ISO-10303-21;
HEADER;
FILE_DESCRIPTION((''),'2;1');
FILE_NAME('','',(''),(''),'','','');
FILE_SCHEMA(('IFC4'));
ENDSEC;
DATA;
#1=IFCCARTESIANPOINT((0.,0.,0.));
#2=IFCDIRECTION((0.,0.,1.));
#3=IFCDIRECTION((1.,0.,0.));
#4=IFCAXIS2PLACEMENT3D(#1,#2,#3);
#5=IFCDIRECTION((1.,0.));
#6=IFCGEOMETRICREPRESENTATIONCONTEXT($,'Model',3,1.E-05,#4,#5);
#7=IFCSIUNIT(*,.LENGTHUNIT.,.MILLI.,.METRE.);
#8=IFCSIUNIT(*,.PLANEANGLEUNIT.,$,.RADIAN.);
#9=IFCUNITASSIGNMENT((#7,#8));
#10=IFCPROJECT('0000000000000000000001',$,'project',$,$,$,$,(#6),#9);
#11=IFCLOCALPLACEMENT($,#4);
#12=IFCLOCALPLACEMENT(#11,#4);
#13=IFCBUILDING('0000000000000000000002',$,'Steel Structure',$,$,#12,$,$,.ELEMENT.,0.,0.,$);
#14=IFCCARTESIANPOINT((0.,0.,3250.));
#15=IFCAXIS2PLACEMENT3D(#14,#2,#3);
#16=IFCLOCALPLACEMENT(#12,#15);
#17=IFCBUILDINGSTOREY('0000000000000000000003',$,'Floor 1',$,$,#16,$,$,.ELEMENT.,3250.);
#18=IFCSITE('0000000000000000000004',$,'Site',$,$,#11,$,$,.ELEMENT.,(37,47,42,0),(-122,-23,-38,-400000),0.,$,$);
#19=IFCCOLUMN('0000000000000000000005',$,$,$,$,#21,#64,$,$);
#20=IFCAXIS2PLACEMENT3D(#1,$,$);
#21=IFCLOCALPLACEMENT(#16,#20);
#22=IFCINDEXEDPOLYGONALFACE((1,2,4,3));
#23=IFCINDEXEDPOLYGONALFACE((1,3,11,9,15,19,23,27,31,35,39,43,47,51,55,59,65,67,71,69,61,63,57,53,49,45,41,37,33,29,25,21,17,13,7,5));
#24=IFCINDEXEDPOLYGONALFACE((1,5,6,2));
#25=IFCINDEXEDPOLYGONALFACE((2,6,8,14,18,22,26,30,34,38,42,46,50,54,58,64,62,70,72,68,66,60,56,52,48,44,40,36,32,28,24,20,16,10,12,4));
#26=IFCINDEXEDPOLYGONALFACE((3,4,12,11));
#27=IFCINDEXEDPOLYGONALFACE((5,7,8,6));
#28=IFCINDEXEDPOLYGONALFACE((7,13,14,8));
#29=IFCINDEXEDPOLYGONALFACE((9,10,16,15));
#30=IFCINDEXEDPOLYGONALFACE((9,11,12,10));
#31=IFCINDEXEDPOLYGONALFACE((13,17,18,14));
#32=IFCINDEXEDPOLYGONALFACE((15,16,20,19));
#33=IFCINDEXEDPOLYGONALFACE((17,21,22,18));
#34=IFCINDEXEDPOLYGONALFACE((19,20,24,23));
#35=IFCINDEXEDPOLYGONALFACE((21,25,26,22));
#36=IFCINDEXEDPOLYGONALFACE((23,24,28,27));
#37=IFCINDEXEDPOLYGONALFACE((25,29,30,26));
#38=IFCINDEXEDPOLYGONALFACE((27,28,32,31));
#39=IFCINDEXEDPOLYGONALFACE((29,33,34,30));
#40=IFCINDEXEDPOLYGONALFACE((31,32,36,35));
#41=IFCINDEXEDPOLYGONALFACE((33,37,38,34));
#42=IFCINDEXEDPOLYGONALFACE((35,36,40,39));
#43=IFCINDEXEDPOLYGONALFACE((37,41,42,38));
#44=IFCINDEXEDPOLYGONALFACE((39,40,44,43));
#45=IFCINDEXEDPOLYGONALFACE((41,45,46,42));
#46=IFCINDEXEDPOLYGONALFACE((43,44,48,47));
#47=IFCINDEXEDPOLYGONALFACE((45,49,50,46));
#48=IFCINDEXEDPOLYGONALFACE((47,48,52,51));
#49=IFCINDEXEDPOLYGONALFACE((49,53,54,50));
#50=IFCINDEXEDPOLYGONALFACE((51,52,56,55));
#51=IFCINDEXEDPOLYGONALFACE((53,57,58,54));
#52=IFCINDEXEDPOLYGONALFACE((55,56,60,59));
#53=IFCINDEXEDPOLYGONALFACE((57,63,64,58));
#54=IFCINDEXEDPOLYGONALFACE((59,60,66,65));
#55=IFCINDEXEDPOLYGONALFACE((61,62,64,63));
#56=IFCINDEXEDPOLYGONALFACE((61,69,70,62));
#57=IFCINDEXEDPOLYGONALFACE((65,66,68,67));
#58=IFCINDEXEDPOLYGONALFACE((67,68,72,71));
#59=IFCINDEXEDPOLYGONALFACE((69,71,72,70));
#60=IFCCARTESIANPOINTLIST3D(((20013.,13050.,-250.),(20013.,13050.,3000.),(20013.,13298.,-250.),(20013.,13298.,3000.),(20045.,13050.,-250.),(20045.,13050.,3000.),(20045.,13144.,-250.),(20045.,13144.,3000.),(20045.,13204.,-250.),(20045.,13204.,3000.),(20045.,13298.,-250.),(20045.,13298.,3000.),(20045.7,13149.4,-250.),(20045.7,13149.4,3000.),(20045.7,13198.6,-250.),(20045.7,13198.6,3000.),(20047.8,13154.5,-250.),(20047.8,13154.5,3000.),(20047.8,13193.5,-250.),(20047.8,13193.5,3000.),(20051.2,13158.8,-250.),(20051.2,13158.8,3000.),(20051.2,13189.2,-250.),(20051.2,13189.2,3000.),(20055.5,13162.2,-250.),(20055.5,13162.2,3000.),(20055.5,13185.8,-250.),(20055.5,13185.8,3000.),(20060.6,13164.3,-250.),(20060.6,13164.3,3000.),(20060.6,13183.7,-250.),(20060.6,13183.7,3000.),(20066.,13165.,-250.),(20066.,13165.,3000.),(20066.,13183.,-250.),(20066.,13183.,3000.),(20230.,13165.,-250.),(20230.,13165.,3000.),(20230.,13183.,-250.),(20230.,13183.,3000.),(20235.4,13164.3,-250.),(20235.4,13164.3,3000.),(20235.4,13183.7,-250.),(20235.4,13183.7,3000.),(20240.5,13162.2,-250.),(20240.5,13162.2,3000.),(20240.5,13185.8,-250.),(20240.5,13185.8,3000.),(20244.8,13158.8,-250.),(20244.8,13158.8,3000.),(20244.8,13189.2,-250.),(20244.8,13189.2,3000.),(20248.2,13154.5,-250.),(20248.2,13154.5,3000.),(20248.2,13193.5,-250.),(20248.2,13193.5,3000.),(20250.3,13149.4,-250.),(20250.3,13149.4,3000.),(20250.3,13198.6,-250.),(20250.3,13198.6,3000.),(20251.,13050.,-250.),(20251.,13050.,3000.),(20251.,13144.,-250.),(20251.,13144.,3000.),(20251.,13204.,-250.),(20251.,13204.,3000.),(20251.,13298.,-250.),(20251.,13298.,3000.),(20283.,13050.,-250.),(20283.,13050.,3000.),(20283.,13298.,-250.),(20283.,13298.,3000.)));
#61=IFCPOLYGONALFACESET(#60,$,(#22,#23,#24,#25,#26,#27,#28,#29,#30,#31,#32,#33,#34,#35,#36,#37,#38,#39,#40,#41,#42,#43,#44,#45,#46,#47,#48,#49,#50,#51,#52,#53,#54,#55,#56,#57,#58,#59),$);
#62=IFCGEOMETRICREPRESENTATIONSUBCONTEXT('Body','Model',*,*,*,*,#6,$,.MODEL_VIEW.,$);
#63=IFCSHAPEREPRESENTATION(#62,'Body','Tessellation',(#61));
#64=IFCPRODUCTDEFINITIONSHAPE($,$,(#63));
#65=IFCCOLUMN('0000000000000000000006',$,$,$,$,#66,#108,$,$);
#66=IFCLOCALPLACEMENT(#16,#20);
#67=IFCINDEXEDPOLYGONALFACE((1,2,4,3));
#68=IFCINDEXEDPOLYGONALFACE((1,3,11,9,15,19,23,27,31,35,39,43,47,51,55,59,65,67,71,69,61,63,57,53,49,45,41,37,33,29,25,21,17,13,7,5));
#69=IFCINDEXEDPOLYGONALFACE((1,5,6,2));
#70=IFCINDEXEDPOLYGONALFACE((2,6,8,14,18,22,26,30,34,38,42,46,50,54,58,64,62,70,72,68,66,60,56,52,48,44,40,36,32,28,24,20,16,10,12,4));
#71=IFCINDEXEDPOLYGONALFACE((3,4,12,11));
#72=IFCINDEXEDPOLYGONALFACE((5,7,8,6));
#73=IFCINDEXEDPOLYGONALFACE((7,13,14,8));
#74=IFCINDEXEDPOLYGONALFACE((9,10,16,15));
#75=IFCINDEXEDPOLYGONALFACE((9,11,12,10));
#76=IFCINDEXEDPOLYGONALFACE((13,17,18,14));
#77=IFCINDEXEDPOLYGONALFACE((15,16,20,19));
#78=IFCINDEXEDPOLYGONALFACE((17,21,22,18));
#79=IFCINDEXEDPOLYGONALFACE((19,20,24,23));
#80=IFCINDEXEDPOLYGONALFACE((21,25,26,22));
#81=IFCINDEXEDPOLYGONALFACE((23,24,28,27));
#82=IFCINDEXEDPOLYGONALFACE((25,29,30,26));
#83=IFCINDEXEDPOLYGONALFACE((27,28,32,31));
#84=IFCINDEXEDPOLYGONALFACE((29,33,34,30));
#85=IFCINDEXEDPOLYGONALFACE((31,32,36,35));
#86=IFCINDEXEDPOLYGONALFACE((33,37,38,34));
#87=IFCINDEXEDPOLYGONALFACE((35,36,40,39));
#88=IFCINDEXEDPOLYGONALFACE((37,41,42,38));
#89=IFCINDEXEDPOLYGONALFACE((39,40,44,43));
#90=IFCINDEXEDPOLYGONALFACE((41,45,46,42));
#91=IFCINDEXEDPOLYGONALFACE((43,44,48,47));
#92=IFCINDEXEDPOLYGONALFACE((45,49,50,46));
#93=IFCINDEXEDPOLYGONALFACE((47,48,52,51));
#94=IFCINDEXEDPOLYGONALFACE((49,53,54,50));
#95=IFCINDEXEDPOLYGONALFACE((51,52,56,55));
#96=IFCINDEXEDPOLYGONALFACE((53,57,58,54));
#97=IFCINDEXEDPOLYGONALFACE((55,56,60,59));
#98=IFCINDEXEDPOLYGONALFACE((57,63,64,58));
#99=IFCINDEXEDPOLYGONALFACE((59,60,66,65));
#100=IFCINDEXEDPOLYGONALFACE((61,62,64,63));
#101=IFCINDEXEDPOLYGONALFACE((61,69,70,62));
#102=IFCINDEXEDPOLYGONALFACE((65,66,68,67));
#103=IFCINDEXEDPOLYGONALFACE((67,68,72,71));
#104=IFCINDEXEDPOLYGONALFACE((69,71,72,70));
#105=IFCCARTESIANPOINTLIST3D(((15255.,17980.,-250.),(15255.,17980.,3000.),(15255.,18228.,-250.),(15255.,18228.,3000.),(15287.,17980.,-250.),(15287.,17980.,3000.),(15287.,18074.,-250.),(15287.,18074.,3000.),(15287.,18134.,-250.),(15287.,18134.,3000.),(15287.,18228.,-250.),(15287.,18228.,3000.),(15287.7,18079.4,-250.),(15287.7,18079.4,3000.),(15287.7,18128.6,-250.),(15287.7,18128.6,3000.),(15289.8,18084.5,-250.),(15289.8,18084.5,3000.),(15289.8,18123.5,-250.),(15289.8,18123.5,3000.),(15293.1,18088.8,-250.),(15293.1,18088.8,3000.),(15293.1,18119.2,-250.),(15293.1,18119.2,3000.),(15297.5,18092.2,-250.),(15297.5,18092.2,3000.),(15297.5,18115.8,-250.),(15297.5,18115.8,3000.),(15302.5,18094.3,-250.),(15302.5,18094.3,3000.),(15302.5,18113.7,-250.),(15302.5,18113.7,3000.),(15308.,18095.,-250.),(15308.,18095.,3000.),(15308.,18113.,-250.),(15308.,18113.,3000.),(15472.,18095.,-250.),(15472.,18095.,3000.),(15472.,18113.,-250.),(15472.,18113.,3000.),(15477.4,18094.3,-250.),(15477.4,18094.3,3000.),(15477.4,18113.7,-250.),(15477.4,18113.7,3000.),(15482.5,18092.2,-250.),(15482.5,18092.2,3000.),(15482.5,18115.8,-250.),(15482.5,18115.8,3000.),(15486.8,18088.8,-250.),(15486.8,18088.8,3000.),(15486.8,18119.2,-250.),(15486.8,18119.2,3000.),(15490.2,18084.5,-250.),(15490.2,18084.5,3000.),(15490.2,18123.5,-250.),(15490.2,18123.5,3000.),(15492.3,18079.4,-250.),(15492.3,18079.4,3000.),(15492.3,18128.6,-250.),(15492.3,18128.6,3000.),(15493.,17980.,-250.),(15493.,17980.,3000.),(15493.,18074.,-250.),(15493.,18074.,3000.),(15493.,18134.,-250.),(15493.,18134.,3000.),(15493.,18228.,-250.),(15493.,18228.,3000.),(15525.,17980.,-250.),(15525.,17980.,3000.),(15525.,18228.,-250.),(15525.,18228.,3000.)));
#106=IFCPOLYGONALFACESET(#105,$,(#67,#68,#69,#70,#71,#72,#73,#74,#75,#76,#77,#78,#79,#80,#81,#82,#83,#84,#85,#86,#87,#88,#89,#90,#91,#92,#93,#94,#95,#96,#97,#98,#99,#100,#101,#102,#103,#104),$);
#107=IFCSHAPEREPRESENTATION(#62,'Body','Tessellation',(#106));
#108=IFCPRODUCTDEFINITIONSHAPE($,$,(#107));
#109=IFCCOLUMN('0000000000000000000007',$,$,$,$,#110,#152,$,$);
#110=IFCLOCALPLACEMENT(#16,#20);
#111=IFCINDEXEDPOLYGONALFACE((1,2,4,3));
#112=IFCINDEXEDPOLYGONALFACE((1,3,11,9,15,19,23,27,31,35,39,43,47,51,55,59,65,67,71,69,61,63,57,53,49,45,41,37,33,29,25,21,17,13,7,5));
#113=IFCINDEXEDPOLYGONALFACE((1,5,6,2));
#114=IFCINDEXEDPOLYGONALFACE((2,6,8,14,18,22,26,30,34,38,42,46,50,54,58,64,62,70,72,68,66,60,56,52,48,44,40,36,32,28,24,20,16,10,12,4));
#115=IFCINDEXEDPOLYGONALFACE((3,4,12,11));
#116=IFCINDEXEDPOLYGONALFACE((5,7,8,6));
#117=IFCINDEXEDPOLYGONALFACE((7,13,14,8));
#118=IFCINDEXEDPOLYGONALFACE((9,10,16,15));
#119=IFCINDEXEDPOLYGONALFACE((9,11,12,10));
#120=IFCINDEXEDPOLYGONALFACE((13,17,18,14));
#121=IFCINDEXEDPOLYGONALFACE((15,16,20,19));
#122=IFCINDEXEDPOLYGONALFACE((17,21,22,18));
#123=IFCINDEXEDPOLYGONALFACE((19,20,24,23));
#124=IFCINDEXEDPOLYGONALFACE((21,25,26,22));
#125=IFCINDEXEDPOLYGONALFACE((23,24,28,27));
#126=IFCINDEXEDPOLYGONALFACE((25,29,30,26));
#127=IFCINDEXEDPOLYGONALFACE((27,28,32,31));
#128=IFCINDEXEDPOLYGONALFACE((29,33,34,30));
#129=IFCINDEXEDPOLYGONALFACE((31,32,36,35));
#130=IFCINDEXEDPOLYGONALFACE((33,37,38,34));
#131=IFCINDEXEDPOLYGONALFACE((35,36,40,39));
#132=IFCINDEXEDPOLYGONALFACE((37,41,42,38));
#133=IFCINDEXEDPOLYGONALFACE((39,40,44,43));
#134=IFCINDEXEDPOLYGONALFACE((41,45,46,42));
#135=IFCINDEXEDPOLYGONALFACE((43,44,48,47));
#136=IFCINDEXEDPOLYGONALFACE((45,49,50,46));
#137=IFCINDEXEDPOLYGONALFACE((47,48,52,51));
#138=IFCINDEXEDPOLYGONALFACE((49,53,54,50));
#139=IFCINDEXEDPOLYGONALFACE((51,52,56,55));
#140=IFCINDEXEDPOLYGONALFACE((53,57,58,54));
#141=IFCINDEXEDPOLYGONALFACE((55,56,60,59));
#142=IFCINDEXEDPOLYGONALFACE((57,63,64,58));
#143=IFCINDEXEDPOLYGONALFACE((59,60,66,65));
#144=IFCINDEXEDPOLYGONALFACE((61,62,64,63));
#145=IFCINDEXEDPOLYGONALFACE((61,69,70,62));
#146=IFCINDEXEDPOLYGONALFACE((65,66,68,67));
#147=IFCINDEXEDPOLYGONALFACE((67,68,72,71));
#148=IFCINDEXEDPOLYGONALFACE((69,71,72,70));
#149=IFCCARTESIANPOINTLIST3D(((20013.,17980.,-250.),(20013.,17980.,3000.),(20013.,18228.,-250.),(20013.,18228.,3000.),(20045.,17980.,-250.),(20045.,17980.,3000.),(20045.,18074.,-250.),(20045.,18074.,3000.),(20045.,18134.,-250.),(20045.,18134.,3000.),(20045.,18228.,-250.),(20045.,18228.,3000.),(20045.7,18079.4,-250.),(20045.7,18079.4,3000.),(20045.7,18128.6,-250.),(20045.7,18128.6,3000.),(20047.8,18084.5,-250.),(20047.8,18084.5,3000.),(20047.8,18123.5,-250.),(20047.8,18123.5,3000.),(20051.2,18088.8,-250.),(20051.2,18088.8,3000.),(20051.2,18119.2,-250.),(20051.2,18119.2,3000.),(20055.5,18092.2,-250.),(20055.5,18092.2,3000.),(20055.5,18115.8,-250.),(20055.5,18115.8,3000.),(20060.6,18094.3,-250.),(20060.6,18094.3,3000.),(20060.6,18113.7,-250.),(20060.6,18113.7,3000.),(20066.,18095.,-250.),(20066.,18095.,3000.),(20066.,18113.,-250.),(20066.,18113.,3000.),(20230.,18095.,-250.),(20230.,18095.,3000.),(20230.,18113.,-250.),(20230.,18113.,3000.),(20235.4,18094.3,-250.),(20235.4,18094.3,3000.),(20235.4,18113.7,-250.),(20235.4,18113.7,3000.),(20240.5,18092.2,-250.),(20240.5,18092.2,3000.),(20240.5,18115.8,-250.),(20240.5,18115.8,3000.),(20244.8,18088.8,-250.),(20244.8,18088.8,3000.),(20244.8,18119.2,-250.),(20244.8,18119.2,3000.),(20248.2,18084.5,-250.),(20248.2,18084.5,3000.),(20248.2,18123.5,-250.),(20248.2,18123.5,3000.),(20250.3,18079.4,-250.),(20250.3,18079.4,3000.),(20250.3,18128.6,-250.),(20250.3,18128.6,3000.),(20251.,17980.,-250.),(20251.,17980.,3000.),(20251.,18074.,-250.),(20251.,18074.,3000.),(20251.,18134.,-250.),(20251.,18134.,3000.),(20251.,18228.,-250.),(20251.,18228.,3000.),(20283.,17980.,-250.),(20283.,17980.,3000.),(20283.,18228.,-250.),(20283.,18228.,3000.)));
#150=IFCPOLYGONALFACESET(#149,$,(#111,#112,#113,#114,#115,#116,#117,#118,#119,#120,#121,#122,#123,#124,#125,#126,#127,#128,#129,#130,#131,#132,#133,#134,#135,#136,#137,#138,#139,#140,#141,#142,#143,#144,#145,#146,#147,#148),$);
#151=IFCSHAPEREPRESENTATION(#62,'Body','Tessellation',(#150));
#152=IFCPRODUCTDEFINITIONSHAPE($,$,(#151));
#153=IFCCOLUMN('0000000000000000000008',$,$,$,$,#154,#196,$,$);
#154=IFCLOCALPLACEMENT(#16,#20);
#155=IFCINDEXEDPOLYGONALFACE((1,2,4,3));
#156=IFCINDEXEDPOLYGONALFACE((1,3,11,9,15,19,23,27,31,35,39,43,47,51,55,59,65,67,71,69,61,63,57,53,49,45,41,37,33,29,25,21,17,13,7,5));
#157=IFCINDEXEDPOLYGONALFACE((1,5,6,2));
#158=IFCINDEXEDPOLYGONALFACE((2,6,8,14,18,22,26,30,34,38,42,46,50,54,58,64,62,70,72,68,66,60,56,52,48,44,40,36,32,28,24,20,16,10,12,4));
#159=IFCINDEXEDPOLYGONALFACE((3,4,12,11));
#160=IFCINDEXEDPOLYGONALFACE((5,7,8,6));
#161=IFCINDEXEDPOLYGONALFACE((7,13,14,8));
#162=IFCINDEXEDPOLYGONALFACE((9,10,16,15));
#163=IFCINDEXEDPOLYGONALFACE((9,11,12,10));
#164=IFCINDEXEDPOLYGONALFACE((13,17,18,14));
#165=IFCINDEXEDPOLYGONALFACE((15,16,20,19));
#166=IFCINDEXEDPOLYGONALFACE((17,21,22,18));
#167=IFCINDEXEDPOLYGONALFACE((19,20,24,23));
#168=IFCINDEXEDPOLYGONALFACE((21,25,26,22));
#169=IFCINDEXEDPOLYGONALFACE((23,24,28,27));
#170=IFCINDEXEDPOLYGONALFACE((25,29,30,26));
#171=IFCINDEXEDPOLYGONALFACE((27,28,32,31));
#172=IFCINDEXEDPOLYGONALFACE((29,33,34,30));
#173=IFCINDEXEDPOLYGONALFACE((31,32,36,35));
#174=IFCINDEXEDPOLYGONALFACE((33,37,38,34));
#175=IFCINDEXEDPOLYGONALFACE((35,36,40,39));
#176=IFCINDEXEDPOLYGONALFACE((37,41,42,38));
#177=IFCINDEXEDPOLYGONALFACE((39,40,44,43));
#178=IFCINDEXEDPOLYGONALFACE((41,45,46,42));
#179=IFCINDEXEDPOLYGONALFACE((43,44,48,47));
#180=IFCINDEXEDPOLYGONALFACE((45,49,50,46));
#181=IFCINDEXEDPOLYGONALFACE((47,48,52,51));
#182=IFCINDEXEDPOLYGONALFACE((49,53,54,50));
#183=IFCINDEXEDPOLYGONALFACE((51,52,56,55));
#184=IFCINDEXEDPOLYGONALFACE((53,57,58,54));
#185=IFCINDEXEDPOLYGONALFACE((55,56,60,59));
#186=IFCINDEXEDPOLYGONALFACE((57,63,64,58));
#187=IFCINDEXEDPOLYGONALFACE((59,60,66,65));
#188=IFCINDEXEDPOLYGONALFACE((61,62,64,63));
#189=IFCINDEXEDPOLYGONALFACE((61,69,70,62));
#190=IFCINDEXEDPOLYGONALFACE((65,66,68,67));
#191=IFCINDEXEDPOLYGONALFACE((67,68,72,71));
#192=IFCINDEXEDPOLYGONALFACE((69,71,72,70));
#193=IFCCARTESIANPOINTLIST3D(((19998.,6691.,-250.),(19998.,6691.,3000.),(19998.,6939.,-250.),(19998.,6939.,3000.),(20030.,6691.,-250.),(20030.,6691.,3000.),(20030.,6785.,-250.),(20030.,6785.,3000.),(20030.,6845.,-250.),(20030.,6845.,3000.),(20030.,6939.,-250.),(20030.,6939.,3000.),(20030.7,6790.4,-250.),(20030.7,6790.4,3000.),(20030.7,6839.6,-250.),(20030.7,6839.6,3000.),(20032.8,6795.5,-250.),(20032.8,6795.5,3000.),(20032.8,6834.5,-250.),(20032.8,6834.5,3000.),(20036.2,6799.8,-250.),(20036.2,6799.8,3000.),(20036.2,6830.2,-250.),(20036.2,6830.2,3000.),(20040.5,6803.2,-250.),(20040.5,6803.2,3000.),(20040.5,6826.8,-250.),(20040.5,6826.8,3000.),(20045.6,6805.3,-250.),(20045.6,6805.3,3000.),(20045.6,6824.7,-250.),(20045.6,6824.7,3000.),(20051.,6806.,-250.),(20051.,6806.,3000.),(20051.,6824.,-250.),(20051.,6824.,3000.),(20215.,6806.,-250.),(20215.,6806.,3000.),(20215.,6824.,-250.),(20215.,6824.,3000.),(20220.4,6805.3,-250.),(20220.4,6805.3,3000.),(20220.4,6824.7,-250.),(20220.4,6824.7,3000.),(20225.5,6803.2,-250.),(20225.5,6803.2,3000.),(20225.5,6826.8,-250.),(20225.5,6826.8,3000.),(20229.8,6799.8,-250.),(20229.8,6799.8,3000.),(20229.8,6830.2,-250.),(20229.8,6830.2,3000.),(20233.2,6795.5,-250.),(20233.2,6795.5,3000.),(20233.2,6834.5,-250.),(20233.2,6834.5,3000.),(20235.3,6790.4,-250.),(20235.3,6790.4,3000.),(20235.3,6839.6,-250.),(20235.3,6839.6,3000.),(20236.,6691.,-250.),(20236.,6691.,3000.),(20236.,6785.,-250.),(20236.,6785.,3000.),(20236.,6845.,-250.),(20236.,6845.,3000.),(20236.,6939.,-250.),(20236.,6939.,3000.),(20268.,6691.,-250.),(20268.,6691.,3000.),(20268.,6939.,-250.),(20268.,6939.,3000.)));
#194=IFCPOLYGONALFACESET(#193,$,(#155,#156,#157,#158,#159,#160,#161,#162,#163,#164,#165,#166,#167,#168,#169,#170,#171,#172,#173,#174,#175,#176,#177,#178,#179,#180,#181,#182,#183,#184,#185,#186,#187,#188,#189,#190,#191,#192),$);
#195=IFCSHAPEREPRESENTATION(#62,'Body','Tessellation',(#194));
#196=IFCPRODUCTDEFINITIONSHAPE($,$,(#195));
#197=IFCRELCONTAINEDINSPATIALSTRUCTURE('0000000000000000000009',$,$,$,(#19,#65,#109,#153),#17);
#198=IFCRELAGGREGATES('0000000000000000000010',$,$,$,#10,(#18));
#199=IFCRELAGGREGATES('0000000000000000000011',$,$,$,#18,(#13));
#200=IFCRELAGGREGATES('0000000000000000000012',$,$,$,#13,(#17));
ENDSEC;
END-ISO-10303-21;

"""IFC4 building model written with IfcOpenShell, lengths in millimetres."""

from ifc_helpers import new_model, si_unit, direction, frame, origin_with_axes, origin_2d_with_axis, place, context, subcontext, project, spatial, i_section, extrude, element, save


model = new_model("IFC4")

# Units and contexts
model_context = context("Model", 3, precision=1e-05, world=origin_with_axes(), true_north=direction((1.0, 0.0)))
body_context = subcontext(model_context, "Body", "Model", "MODEL_VIEW")
ifc_project = project(units=[si_unit("LENGTHUNIT", "METRE", prefix="MILLI"), si_unit("PLANEANGLEUNIT", "RADIAN")], contexts=[model_context])

# Site, building, storey
site_placement = place(None, origin_with_axes())
site = spatial("IfcSite", under=ifc_project, at=site_placement, Name="Site", CompositionType="ELEMENT", RefLatitude=(37, 47, 42, 0), RefLongitude=(-122, -23, -38, -400000), RefElevation=0.0)
building_placement = place(site_placement, origin_with_axes())
building = spatial("IfcBuilding", under=site, at=building_placement, Name="Steel Structure", CompositionType="ELEMENT", ElevationOfRefHeight=0.0, ElevationOfTerrain=0.0)
storey_placement = place(building_placement, frame((0.0, 0.0, 3250.0), z_axis=(0.0, 0.0, 1.0), x_axis=(1.0, 0.0, 0.0)))
storey = spatial("IfcBuildingStorey", under=building, at=storey_placement, Name="Floor 1", CompositionType="ELEMENT", Elevation=3250.0)

# Columns
for number, where, z_axis, x_axis in (
    (1, (20148.0, 13174.0, -250.0), (0.0, 0.0, 1.0), (0.0, 1.0, 0.0)),
    (2, (15390.0, 18104.0, -250.0), (0.0, 0.0, 1.0), (0.0, 1.0, 0.0)),
    (3, (20148.0, 18104.0, -250.0), (0.0, 0.0, 1.0), (0.0, 1.0, 0.0)),
):
    element("IfcColumn", number, at=place(storey_placement, frame(where, z_axis=z_axis, x_axis=x_axis)), inside=storey, context=body_context, shape_type="SweptSolid", body=[
        extrude(i_section(OverallWidth=248.0, OverallDepth=270.0, WebThickness=18.0, FlangeThickness=32.0, FilletRadius=21.0, at=origin_2d_with_axis()), origin_with_axes(), (0.0, 0.0, 1.0), 3250.0),
    ])
column_1_placement = place(storey_placement, frame((20133.0, 6815.0, -250.0), z_axis=(0.0, 0.0, 1.0), x_axis=(0.0, -1.0, 0.0)))
element("IfcColumn", 4, at=column_1_placement, inside=storey, context=body_context, shape_type="SweptSolid", body=[
    extrude(i_section(OverallWidth=248.0, OverallDepth=270.0, WebThickness=18.0, FlangeThickness=32.0, FilletRadius=21.0, at=origin_2d_with_axis()), origin_with_axes(), (0.0, 0.0, 1.0), 3250.0),
])

save(model, "model.ifc")
